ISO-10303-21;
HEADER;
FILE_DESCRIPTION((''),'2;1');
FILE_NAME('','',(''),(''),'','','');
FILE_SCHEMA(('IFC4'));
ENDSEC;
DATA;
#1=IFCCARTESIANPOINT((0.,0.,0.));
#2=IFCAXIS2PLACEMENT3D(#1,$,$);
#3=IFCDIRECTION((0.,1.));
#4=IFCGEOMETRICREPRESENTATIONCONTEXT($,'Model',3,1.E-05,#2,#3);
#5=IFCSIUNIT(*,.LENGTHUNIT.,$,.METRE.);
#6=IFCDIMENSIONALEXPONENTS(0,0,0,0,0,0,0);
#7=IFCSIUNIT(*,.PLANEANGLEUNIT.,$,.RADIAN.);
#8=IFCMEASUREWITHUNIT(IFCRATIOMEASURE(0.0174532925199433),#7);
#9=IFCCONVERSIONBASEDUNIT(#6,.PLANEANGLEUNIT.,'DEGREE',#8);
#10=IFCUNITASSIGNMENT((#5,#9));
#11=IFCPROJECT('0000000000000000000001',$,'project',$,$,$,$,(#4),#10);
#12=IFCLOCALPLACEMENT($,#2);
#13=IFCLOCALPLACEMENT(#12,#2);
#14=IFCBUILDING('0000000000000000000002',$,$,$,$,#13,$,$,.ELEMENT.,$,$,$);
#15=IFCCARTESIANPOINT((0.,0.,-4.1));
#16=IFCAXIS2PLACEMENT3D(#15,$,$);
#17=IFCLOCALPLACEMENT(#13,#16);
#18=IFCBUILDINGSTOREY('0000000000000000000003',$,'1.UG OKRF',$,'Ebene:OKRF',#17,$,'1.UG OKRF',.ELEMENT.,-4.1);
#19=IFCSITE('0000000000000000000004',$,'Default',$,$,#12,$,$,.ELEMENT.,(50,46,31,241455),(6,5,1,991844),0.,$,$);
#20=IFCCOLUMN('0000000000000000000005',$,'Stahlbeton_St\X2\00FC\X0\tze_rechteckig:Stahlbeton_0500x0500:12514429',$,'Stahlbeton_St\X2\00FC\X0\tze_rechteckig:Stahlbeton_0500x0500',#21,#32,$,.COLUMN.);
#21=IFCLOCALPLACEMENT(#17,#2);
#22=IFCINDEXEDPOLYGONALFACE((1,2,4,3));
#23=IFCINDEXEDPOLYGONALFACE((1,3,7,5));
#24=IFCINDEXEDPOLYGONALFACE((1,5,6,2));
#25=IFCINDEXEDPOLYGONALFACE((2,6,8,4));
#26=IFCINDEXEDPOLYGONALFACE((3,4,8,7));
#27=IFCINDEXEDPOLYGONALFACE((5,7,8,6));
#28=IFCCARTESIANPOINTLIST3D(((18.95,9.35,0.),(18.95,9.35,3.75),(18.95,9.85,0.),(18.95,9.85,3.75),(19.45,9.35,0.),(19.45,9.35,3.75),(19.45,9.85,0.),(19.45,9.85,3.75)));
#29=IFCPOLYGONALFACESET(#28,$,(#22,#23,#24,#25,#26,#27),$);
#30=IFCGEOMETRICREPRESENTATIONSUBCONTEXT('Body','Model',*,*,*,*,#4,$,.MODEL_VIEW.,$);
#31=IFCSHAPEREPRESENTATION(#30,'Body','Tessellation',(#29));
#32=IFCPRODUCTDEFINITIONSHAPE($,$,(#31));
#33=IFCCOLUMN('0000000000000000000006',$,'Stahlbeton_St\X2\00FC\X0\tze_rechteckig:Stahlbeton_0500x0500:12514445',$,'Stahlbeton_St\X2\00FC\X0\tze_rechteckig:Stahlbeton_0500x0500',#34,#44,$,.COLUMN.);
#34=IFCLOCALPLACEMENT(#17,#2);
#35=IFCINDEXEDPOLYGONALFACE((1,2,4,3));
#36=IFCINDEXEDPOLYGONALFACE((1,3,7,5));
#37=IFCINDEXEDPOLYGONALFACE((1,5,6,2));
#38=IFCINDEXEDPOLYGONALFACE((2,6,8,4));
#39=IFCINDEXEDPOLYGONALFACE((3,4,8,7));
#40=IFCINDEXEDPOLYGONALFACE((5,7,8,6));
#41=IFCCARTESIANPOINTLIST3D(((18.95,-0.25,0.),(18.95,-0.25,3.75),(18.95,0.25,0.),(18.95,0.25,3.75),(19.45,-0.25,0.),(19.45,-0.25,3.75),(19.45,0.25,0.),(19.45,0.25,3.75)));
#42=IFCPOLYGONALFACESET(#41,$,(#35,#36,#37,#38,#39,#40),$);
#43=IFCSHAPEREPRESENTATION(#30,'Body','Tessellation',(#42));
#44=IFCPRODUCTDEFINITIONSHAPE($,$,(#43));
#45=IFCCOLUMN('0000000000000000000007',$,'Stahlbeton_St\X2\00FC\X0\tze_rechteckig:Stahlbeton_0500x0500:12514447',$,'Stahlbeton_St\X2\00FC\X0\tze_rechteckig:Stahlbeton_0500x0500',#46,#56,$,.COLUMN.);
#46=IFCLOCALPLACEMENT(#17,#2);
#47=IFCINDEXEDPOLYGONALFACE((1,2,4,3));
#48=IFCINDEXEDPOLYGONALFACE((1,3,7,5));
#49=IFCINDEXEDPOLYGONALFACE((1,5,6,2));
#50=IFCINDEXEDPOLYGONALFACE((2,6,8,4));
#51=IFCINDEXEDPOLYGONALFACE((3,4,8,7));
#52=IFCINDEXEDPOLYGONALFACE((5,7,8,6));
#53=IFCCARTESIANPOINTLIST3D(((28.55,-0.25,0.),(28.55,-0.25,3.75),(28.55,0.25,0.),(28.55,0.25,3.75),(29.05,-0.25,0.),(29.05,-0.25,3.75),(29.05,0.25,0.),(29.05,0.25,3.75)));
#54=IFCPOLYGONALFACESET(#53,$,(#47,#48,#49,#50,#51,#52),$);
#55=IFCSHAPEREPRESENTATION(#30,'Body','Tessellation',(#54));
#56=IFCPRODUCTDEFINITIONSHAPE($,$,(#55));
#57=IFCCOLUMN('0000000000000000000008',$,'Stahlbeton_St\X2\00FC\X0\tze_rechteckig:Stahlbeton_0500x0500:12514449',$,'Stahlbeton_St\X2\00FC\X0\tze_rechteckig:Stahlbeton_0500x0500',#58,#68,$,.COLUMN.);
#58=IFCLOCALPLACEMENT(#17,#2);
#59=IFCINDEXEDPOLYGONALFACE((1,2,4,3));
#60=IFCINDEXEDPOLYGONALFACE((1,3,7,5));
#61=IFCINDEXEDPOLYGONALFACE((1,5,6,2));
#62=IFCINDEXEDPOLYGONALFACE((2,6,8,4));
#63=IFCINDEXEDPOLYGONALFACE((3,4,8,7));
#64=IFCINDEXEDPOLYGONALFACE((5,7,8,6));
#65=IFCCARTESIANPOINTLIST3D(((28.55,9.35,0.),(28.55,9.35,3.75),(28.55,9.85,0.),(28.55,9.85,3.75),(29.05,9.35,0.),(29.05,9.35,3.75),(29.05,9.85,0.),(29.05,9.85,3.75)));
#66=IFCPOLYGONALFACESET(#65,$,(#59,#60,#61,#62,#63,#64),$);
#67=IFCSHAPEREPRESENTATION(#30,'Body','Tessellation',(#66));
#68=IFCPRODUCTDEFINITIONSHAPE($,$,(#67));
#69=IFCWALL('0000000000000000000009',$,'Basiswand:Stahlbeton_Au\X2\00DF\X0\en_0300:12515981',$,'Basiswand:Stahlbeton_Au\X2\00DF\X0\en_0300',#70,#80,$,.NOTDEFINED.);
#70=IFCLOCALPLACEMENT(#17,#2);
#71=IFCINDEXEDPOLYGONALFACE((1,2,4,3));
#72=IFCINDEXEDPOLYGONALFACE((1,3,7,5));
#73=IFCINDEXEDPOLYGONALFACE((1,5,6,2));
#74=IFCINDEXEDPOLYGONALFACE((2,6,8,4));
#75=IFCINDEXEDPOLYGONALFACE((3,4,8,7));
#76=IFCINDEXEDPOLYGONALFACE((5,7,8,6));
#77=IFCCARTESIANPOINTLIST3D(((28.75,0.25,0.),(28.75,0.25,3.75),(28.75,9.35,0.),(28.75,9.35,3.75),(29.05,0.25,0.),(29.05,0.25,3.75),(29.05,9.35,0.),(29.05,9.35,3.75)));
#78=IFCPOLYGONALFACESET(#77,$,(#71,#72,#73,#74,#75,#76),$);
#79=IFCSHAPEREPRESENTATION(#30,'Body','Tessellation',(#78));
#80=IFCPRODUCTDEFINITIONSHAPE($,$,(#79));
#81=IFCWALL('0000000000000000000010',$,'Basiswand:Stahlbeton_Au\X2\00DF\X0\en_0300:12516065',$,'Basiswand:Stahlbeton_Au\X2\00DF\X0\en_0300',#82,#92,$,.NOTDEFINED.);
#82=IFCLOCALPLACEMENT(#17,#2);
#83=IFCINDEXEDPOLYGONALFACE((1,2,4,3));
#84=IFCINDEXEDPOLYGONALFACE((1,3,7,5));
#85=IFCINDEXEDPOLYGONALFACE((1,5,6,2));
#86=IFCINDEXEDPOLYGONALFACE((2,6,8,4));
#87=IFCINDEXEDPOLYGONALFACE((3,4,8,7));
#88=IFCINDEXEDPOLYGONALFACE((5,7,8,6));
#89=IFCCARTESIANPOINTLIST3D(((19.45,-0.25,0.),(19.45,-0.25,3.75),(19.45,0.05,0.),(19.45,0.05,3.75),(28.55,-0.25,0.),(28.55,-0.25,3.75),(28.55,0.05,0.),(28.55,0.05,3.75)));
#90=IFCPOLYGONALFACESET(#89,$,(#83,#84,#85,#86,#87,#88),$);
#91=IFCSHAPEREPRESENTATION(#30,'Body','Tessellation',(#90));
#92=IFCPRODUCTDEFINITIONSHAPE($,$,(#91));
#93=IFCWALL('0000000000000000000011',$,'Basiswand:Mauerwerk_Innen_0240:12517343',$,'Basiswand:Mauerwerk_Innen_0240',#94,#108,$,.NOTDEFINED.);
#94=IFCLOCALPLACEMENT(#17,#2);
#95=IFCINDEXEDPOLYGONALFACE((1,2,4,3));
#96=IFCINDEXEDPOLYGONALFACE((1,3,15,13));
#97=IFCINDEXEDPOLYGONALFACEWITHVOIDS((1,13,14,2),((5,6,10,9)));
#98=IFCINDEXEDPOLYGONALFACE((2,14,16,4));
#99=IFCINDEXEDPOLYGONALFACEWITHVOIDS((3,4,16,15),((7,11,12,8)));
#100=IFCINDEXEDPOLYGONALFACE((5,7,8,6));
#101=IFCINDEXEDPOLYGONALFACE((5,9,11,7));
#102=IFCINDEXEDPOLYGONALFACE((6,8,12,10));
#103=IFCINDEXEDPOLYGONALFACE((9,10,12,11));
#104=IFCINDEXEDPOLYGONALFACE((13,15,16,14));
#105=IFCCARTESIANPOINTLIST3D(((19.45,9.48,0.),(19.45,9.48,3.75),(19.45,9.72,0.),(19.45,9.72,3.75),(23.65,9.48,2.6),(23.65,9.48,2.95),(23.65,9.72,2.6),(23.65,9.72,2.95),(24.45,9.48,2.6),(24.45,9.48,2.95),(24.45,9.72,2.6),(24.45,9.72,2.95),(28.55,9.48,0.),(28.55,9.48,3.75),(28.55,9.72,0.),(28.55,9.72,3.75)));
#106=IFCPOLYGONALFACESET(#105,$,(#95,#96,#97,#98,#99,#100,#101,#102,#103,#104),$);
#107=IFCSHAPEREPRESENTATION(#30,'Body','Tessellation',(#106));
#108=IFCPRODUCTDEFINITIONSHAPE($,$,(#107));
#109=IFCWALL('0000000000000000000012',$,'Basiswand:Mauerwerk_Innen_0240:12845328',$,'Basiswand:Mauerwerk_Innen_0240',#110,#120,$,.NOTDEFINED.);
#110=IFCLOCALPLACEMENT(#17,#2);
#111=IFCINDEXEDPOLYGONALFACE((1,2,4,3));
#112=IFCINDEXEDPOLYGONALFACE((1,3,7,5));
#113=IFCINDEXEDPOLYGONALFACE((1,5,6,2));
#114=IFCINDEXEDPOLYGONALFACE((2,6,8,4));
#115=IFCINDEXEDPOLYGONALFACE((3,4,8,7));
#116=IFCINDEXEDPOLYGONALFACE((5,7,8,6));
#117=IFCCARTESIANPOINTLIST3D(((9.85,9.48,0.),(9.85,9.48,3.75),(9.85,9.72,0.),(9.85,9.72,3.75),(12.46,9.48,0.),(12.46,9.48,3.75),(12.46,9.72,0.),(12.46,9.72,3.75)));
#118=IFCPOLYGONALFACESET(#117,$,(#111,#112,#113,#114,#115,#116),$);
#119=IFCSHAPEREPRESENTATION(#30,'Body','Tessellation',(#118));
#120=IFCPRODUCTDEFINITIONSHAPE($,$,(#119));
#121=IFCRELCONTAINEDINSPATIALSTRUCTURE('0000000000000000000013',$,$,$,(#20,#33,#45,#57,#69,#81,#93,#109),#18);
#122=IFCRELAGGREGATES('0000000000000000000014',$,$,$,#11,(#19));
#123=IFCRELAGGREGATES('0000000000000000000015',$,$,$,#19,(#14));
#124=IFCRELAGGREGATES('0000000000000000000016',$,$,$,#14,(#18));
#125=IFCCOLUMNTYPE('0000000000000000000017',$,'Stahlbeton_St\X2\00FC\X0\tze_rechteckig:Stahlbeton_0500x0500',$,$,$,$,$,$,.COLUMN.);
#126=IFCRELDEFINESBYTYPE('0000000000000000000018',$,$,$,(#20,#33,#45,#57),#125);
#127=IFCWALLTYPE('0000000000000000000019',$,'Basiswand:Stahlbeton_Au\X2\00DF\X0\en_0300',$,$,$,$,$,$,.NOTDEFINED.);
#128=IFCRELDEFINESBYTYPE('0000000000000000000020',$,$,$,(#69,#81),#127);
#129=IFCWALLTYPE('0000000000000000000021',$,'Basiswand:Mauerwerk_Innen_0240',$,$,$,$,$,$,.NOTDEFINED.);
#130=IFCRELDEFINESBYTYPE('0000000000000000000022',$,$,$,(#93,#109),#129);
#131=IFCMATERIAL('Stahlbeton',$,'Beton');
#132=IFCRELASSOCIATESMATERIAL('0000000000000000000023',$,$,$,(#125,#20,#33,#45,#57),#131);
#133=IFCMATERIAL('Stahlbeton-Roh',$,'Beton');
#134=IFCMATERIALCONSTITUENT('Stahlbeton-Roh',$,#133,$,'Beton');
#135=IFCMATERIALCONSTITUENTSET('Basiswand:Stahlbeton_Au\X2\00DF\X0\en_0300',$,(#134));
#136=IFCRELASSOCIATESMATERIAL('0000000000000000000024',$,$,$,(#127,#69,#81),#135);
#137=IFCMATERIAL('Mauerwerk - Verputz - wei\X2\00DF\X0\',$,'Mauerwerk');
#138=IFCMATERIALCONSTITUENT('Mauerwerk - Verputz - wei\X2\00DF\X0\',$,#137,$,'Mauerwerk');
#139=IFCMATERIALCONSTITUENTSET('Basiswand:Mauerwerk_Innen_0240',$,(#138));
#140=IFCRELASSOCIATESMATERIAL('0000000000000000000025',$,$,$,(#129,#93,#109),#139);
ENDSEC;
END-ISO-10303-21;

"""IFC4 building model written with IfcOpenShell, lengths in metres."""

from ifc_helpers import new_model, entity, si_unit, converted_unit, direction, frame, origin, place, context, subcontext, project, spatial, indexed_curve, outline, extrude, source, transform, mapped, material, constituent, constituent_set, type_object, type_shapes, element, save


model = new_model("IFC4")

# Units and contexts
model_context = context("Model", 3, precision=1e-05, world=origin(), true_north=direction((0.0, 1.0)))
body_context = subcontext(model_context, "Body", "Model", "MODEL_VIEW")
ifc_project = project(units=[si_unit("LENGTHUNIT", "METRE"), converted_unit("PLANEANGLEUNIT", "DEGREE", entity("IfcRatioMeasure", 0.0174532925199433), si_unit("PLANEANGLEUNIT", "RADIAN"), dimensions=[0, 0, 0, 0, 0, 0, 0])], contexts=[model_context])

# Site, building, storey
site_placement = place(None, origin())
site = spatial("IfcSite", under=ifc_project, at=site_placement, Name="Default", CompositionType="ELEMENT", RefLatitude=(50, 46, 31, 241455), RefLongitude=(6, 5, 1, 991844), RefElevation=0.0)
building_placement = place(site_placement, origin())
building = spatial("IfcBuilding", under=site, at=building_placement, CompositionType="ELEMENT")
storey_placement = place(building_placement, frame((0.0, 0.0, -4.1)))
storey = spatial("IfcBuildingStorey", under=building, at=storey_placement, Name="1.UG OKRF", ObjectType="Ebene:OKRF", LongName="1.UG OKRF", CompositionType="ELEMENT", Elevation=-4.1)

# Columns
ifc_material_1 = material(Name="Stahlbeton", Category="Beton")
column_type = type_object("IfcColumnType", Name="Stahlbeton_Stütze_rechteckig:Stahlbeton_0500x0500", PredefinedType="COLUMN", material=ifc_material_1)
shared_shape = source(origin(), body_context, "Body", "SweptSolid", [
    extrude(outline(indexed_curve([(-0.25, -0.25), (0.25, -0.25), (0.25, 0.25), (-0.25, 0.25), (-0.25, -0.25)], self_intersect=False)), frame((0.0, 0.0, -4.1), z_axis=(0.0, 0.0, 1.0), x_axis=(0.0, -1.0, 0.0)), (0.0, 0.0, 1.0), 3.75),
])
type_shapes(column_type, [shared_shape])
for number, where, name in (
    (1, (19.2, 9.6, 4.1), "Stahlbeton_Stütze_rechteckig:Stahlbeton_0500x0500:12514429"),
    (2, (19.2, 0.0, 4.1), "Stahlbeton_Stütze_rechteckig:Stahlbeton_0500x0500:12514445"),
    (3, (28.8, 0.0, 4.1), "Stahlbeton_Stütze_rechteckig:Stahlbeton_0500x0500:12514447"),
    (4, (28.8, 9.6, 4.1), "Stahlbeton_Stütze_rechteckig:Stahlbeton_0500x0500:12514449"),
):
    element("IfcColumn", number, at=place(storey_placement, frame(where)), inside=storey, type_object=column_type, material=ifc_material_1, Name=name, ObjectType="Stahlbeton_Stütze_rechteckig:Stahlbeton_0500x0500", PredefinedType="COLUMN", context=body_context, shape_type="MappedRepresentation", body=[
        mapped(shared_shape, transform((0.0, 0.0, 0.0), scale=1.0)),
    ])

# Walls
ifc_material_2 = material(Name="Stahlbeton-Roh", Category="Beton")
ifc_constituent_1 = constituent(ifc_material_2, Name="Stahlbeton-Roh", Category="Beton")
ifc_constituent_set_1 = constituent_set(constituents=[ifc_constituent_1], Name="Basiswand:Stahlbeton_Außen_0300")
wall_type_1 = type_object("IfcWallType", Name="Basiswand:Stahlbeton_Außen_0300", PredefinedType="NOTDEFINED", material=ifc_constituent_set_1)
wall_1_placement = place(storey_placement, frame((28.9, 9.35, 0.0), z_axis=(0.0, 0.0, 1.0), x_axis=(0.0, -1.0, 0.0)))
element("IfcWall", 5, at=wall_1_placement, inside=storey, type_object=wall_type_1, material=ifc_constituent_set_1, Name="Basiswand:Stahlbeton_Außen_0300:12515981", ObjectType="Basiswand:Stahlbeton_Außen_0300", PredefinedType="NOTDEFINED", context=body_context, shape_type="SweptSolid", body=[
    extrude(outline(indexed_curve([(-0.15, -4.55), (0.15, -4.55), (0.15, 4.55), (-0.15, 4.55), (-0.15, -4.55)], self_intersect=False)), frame((4.55, 0.0, 0.0), z_axis=(0.0, 0.0, 1.0), x_axis=(0.0, 1.0, 0.0)), (0.0, 0.0, 1.0), 3.75),
])
wall_2_placement = place(storey_placement, frame((28.55, -0.1, 0.0), z_axis=(0.0, 0.0, 1.0), x_axis=(-1.0, 0.0, 0.0)))
element("IfcWall", 6, at=wall_2_placement, inside=storey, type_object=wall_type_1, material=ifc_constituent_set_1, Name="Basiswand:Stahlbeton_Außen_0300:12516065", ObjectType="Basiswand:Stahlbeton_Außen_0300", PredefinedType="NOTDEFINED", context=body_context, shape_type="SweptSolid", body=[
    extrude(outline(indexed_curve([(-0.15, -4.55), (0.15, -4.55), (0.15, 4.55), (-0.15, 4.55), (-0.15, -4.55)], self_intersect=False)), frame((4.55, 0.0, 0.0), z_axis=(0.0, 0.0, 1.0), x_axis=(0.0, 1.0, 0.0)), (0.0, 0.0, 1.0), 3.75),
])

# Wall, opening
ifc_material_3 = material(Name="Mauerwerk - Verputz - weiß", Category="Mauerwerk")
ifc_constituent_2 = constituent(ifc_material_3, Name="Mauerwerk - Verputz - weiß", Category="Mauerwerk")
ifc_constituent_set_2 = constituent_set(constituents=[ifc_constituent_2], Name="Basiswand:Mauerwerk_Innen_0240")
wall_type_2 = type_object("IfcWallType", Name="Basiswand:Mauerwerk_Innen_0240", PredefinedType="NOTDEFINED", material=ifc_constituent_set_2)
wall_3_placement = place(storey_placement, frame((19.45, 9.6, 0.0)))
wall_3 = element("IfcWall", 7, at=wall_3_placement, inside=storey, type_object=wall_type_2, material=ifc_constituent_set_2, Name="Basiswand:Mauerwerk_Innen_0240:12517343", ObjectType="Basiswand:Mauerwerk_Innen_0240", PredefinedType="NOTDEFINED", context=body_context, shape_type="SweptSolid", body=[
    extrude(outline(indexed_curve([(-1.875, -4.55), (1.875, -4.55), (1.875, 4.55), (-1.875, 4.55), (-1.875, -4.55)], self_intersect=False), holes=[indexed_curve([(1.075, -0.35), (0.725, -0.35), (0.725, 0.45), (1.075, 0.45), (1.075, -0.35)], self_intersect=False)]), frame((4.55, -0.12, 1.875), z_axis=(0.0, 1.0, 0.0), x_axis=(0.0, 0.0, 1.0)), (0.0, 0.0, 1.0), 0.24),
])
opening_1_placement = place(wall_3_placement, origin())
element("IfcOpeningElement", 8, at=opening_1_placement, cuts=wall_3, ObjectType="Opening", PredefinedType="OPENING", context=body_context, shape_type="SweptSolid", body=[
    extrude(outline(indexed_curve([(-0.175, -0.4), (0.175, -0.4), (0.175, 0.4), (-0.175, 0.4), (-0.175, -0.4)], self_intersect=False)), frame((4.6, -0.12, 2.775), z_axis=(0.0, 1.0, 0.0), x_axis=(0.0, 0.0, -1.0)), (0.0, 0.0, 1.0), 0.24),
])

# Wall
wall_4_placement = place(storey_placement, frame((12.46, 9.6, 0.0), z_axis=(0.0, 0.0, 1.0), x_axis=(-1.0, 0.0, 0.0)))
element("IfcWall", 9, at=wall_4_placement, inside=storey, type_object=wall_type_2, material=ifc_constituent_set_2, Name="Basiswand:Mauerwerk_Innen_0240:12845328", ObjectType="Basiswand:Mauerwerk_Innen_0240", PredefinedType="NOTDEFINED", context=body_context, shape_type="SweptSolid", body=[
    extrude(outline(indexed_curve([(-0.12, -1.305), (0.12, -1.305), (0.12, 1.305), (-0.12, 1.305), (-0.12, -1.305)], self_intersect=False)), frame((1.305, 0.0, 0.0), z_axis=(0.0, 0.0, 1.0), x_axis=(0.0, 1.0, 0.0)), (0.0, 0.0, 1.0), 3.75),
])

save(model, "model.ifc")
